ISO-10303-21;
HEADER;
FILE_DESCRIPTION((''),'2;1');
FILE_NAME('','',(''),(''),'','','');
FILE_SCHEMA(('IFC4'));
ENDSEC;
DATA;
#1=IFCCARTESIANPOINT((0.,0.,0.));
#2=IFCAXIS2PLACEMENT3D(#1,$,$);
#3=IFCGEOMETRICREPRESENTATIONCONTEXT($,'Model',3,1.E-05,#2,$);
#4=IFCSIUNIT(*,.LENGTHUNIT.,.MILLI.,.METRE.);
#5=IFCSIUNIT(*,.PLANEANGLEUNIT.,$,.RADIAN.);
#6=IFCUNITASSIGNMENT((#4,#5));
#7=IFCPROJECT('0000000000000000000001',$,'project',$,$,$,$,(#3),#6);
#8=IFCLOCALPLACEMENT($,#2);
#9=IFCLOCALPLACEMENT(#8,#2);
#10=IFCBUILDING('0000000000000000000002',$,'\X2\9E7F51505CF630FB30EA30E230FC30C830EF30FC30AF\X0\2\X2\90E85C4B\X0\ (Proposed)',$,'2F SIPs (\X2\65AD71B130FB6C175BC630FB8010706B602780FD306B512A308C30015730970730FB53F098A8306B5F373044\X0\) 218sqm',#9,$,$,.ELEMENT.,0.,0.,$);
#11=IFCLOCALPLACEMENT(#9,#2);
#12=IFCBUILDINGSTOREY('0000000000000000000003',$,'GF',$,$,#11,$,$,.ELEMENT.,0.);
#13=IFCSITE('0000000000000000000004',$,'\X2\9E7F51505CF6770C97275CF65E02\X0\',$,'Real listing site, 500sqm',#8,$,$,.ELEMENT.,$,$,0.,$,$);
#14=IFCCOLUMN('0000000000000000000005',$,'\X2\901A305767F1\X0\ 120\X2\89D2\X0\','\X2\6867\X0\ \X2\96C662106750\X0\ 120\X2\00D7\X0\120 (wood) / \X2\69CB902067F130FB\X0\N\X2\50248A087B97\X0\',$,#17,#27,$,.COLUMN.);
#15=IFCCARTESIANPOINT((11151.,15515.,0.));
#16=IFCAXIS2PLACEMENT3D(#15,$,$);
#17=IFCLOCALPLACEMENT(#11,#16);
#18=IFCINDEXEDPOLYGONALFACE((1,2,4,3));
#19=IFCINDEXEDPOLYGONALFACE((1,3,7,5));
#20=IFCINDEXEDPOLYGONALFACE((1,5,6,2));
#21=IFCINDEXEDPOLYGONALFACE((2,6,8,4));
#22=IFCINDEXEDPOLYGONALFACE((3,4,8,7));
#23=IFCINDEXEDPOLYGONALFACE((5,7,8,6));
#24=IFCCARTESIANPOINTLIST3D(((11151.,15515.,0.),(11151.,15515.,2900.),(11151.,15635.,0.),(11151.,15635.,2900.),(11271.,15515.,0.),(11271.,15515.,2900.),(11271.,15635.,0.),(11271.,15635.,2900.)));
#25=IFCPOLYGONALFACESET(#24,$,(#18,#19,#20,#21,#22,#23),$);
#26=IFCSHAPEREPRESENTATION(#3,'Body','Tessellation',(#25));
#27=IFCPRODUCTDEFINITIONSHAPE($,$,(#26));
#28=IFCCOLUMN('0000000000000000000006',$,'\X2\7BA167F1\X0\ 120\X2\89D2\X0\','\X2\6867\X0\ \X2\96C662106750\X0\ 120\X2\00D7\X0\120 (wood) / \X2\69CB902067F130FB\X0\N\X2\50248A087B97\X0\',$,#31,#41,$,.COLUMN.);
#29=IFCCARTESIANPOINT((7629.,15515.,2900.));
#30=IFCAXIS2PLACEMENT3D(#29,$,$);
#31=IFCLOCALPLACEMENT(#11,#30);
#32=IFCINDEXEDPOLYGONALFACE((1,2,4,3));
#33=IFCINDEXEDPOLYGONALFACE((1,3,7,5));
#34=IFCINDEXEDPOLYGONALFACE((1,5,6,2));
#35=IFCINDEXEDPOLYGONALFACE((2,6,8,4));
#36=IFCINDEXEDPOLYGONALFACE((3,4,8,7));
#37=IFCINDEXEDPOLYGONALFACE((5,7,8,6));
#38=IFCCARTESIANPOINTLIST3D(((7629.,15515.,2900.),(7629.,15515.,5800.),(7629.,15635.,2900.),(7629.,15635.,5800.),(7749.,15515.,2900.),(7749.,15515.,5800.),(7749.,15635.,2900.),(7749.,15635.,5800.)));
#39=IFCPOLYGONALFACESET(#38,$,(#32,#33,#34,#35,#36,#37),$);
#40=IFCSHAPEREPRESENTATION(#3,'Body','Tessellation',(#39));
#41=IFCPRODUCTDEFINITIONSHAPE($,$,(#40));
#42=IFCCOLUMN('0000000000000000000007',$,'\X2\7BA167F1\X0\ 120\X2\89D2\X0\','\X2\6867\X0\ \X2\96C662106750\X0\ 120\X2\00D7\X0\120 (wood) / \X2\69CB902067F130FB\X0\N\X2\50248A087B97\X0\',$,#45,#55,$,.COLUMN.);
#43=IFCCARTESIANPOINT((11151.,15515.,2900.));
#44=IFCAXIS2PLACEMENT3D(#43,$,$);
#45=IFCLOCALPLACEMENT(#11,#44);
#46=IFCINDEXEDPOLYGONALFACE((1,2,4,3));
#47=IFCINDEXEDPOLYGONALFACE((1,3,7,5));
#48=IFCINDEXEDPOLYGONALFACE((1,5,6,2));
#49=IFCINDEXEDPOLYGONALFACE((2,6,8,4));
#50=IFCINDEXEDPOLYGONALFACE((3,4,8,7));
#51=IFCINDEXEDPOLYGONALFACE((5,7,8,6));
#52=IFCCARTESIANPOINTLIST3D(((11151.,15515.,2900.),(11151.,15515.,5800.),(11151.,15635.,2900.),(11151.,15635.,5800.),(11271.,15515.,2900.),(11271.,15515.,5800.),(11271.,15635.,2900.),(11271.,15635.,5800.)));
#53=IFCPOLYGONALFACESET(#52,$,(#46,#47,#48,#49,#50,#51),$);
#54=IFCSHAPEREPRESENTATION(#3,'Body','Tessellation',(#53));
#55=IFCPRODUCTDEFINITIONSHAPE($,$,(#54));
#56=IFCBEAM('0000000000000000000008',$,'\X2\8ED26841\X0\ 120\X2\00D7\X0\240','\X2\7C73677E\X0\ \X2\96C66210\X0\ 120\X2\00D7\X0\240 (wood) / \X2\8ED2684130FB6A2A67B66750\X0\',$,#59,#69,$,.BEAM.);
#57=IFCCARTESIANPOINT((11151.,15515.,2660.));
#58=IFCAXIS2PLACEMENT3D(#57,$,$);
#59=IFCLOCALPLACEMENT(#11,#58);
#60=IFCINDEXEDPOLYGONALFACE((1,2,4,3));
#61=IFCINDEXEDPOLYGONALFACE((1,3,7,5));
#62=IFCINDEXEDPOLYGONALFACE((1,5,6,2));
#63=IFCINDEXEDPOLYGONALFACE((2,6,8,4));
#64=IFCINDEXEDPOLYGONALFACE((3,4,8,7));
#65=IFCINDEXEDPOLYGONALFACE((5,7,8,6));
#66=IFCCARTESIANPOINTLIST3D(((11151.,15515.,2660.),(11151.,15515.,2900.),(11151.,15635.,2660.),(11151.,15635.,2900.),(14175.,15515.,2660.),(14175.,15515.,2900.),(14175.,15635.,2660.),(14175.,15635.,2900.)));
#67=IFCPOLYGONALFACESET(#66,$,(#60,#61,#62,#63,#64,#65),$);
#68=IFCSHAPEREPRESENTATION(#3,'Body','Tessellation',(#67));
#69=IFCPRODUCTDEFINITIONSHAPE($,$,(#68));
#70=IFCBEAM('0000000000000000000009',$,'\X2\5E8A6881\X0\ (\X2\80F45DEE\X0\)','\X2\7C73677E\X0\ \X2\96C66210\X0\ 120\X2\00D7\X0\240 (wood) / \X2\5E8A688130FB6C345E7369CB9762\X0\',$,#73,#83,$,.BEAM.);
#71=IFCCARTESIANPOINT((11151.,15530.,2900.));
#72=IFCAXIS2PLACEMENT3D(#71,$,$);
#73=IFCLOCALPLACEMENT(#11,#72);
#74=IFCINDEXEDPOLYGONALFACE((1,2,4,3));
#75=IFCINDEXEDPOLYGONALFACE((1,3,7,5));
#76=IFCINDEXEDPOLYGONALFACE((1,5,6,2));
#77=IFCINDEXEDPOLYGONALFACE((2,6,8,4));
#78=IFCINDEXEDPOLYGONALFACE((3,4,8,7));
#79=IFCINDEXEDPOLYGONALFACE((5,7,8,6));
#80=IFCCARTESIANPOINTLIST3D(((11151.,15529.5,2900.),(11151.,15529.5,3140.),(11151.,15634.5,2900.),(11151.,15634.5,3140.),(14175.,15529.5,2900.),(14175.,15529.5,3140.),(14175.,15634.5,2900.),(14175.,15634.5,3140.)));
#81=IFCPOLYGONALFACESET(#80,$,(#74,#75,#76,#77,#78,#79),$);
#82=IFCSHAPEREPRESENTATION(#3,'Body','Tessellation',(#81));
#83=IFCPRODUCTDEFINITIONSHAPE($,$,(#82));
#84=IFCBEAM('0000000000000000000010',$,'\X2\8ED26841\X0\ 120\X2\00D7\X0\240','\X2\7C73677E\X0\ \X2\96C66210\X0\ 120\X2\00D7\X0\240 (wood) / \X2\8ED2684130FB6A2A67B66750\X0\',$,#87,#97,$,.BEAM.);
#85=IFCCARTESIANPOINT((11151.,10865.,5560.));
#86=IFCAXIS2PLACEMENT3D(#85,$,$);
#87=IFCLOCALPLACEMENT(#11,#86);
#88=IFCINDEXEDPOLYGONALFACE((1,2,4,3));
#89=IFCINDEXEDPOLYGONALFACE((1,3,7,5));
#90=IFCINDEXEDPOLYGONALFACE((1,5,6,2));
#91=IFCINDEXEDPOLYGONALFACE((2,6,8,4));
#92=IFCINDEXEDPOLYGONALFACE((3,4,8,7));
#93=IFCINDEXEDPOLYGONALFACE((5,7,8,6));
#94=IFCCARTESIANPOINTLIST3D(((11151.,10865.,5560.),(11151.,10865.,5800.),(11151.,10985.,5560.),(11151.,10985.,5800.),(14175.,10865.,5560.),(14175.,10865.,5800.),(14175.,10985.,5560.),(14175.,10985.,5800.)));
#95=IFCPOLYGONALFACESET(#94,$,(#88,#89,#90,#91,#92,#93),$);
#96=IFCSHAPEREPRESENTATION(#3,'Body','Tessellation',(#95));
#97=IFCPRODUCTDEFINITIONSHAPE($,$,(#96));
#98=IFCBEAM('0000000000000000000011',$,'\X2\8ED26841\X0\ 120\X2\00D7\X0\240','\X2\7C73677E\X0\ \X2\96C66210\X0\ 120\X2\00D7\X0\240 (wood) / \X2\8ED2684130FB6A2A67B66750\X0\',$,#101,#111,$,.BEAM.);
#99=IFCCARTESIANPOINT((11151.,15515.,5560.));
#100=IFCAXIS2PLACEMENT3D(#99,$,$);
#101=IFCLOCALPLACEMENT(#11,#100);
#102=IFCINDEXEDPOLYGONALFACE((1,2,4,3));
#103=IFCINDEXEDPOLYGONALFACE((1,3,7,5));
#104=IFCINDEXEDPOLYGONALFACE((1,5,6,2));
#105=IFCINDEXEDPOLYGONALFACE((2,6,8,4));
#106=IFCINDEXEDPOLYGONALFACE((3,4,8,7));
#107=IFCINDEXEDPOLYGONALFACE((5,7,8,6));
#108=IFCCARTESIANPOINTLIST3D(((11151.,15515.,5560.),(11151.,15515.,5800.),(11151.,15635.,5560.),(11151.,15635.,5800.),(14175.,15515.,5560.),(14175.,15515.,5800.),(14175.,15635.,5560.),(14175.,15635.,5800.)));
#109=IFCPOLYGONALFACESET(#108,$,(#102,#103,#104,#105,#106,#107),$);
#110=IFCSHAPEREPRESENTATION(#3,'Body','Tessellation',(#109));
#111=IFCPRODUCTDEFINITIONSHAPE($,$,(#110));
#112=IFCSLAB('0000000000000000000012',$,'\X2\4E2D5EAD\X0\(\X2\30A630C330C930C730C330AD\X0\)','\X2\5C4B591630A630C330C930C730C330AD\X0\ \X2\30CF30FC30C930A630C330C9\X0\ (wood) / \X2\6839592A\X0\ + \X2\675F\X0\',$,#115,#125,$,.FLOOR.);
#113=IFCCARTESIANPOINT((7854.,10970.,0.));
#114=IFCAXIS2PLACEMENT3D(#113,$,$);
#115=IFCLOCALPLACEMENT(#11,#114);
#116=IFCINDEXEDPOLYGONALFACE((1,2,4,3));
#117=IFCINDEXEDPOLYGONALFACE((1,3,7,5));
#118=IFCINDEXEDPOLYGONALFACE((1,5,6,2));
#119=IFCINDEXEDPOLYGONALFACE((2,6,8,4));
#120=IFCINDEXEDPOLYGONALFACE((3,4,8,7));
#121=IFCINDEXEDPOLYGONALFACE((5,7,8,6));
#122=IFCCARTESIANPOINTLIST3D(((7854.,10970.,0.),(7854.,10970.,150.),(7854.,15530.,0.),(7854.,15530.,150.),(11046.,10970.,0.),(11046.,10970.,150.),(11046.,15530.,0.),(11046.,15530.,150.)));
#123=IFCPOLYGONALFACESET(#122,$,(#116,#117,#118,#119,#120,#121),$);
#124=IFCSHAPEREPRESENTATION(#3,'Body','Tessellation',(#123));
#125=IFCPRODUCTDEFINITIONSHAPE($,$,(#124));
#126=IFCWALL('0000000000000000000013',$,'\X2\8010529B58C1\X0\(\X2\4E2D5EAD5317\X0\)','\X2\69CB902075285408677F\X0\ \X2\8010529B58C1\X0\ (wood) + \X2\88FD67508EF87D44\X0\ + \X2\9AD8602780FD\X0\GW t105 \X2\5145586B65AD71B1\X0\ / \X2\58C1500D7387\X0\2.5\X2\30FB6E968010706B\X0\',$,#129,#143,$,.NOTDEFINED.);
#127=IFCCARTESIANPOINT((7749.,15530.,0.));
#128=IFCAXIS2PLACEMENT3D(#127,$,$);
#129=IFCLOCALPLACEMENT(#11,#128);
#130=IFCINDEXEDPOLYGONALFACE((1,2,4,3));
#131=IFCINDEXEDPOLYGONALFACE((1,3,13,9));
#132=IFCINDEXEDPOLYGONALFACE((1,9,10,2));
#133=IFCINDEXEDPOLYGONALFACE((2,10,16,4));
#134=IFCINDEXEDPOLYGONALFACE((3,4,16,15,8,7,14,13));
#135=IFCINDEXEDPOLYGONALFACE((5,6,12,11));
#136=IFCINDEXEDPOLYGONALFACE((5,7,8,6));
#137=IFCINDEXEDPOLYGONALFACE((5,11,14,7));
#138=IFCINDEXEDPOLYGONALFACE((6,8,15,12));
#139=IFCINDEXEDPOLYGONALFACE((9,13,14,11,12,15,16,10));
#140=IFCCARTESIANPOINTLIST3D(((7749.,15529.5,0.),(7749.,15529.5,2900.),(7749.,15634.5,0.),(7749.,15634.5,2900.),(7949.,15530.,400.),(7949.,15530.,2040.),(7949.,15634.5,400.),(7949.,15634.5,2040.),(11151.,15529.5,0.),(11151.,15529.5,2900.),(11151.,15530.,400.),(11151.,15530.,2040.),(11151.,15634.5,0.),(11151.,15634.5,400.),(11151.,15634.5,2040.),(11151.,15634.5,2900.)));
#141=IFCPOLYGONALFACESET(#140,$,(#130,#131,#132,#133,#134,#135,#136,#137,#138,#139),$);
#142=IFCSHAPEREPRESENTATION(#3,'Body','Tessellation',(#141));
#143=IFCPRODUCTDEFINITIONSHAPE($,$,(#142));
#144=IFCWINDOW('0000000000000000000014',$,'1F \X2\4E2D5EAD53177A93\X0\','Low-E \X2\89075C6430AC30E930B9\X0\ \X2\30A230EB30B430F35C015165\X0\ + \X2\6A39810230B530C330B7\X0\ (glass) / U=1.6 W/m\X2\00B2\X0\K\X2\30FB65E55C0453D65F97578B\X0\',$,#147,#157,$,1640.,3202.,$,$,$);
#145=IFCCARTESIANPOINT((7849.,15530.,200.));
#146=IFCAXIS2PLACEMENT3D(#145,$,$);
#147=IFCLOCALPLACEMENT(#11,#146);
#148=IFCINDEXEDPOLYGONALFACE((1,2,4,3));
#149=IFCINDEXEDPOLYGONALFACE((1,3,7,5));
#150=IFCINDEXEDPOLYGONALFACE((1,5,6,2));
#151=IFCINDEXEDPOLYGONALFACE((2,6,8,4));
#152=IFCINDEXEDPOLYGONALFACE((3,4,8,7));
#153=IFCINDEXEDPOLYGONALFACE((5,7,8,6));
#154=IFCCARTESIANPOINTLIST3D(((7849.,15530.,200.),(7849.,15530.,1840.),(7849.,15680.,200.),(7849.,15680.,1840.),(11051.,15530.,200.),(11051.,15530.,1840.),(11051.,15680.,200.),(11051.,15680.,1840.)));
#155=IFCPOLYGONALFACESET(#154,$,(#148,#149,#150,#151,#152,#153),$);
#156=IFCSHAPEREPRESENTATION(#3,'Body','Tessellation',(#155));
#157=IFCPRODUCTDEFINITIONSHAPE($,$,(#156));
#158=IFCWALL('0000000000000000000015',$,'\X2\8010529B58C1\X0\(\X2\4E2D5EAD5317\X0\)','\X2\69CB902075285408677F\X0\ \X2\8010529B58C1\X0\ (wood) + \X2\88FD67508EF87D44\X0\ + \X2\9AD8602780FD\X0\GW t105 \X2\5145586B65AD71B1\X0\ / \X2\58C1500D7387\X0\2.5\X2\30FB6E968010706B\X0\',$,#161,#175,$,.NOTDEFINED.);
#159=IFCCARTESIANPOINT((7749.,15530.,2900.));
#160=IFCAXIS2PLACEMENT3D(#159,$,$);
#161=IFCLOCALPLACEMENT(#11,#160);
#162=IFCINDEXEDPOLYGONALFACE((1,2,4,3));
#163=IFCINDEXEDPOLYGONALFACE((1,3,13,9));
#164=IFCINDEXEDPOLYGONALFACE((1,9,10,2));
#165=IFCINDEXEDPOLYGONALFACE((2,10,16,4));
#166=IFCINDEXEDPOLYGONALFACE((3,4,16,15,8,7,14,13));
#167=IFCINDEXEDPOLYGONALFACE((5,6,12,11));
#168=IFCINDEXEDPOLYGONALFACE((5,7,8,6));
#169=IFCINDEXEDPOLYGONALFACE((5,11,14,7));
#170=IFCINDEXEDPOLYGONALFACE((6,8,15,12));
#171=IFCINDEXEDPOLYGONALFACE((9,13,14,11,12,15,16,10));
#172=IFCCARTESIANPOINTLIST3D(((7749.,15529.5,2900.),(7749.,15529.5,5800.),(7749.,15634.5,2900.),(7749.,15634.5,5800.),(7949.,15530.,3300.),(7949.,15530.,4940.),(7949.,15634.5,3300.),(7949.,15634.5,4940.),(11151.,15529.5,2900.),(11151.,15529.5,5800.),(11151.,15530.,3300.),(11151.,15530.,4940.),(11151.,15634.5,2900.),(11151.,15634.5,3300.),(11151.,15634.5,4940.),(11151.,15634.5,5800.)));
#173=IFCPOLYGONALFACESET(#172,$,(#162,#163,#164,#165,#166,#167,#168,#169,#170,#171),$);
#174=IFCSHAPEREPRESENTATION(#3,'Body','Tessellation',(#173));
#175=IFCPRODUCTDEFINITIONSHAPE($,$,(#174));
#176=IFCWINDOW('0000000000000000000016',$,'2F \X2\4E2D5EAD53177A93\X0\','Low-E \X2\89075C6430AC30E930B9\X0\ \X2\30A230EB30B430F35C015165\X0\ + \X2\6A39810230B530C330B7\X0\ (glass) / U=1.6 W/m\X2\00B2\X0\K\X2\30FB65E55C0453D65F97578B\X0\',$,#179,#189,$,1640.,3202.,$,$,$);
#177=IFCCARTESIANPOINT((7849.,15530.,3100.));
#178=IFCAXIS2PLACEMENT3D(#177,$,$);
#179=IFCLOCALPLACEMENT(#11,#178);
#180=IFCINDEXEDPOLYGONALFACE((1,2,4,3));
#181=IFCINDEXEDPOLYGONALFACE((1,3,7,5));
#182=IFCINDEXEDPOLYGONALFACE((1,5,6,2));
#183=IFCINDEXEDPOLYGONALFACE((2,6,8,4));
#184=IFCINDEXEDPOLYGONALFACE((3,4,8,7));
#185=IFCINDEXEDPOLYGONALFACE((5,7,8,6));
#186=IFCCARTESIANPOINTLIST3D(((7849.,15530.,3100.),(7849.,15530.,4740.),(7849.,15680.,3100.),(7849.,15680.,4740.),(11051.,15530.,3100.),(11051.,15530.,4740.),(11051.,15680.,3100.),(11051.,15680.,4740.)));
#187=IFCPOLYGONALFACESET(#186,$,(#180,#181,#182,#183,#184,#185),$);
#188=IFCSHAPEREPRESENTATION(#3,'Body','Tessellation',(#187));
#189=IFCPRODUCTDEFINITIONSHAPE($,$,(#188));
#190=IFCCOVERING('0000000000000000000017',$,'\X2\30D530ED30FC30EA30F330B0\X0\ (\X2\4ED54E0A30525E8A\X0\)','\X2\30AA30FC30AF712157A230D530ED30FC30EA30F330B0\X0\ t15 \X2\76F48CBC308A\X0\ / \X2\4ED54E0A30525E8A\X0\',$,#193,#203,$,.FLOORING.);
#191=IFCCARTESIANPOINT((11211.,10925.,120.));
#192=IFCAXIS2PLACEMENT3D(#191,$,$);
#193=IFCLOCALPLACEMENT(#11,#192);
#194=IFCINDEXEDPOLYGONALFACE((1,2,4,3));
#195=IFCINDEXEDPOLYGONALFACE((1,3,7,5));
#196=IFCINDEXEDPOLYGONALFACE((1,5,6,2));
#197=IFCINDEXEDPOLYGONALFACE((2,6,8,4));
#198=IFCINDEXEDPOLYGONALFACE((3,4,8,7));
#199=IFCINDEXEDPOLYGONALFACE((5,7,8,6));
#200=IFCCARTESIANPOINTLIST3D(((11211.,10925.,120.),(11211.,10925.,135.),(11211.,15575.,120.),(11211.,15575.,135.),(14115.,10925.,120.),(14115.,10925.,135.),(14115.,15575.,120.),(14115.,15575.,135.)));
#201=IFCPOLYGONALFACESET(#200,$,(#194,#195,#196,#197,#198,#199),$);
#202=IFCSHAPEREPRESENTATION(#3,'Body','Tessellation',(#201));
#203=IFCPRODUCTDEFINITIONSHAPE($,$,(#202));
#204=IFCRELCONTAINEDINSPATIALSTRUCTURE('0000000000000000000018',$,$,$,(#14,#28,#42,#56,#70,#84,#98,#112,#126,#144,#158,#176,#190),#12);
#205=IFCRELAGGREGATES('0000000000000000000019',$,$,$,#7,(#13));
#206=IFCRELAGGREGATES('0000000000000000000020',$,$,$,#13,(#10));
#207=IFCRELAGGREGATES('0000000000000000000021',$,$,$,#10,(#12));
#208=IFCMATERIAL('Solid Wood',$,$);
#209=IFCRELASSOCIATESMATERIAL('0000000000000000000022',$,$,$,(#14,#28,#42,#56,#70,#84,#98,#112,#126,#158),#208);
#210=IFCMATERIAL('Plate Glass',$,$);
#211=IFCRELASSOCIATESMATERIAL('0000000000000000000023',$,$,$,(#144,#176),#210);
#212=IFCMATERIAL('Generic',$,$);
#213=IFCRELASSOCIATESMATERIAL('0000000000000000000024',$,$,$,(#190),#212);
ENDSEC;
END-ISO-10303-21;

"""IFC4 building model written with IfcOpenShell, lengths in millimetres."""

from ifc_helpers import new_model, si_unit, frame, frame_2d, origin, place, context, project, spatial, rectangle, extrude, material, element, fill, save


model = new_model("IFC4")

# Units and contexts
model_context = context("Model", 3, precision=1e-05, world=origin())
ifc_project = project(units=[si_unit("LENGTHUNIT", "METRE", prefix="MILLI"), si_unit("PLANEANGLEUNIT", "RADIAN")], contexts=[model_context])

# Site, building, storey
site_placement = place(None, origin())
site = spatial("IfcSite", under=ifc_project, at=site_placement, Name="鹿児島県霧島市", ObjectType="Real listing site, 500sqm", CompositionType="ELEMENT", RefElevation=0.0)
building_placement = place(site_placement, origin())
building = spatial("IfcBuilding", under=site, at=building_placement, Name="鹿児島・リモートワーク2部屋 (Proposed)", ObjectType="2F SIPs (断熱・気密・耐火性能に優れ、地震・台風に強い) 218sqm", CompositionType="ELEMENT", ElevationOfRefHeight=0.0, ElevationOfTerrain=0.0)
storey_placement = place(building_placement, origin())
storey = spatial("IfcBuildingStorey", under=building, at=storey_placement, Name="GF", CompositionType="ELEMENT", Elevation=0.0)

# Columns
ifc_material_1 = material(Name="Solid Wood")
column_1_placement = place(storey_placement, frame((11151.0, 15515.0, 0.0)))
element("IfcColumn", 1, at=column_1_placement, inside=storey, material=ifc_material_1, Name="通し柱 120角", Description="桧 集成材 120×120 (wood) / 構造柱・N値計算", PredefinedType="COLUMN", context=model_context, shape_type="SweptSolid", body=[
    extrude(rectangle(XDim=120.0, YDim=120.0, at=frame_2d((60.0, 60.0))), frame((11151.0, 15515.0, 0.0)), (0.0, 0.0, 1.0), 2900.0),
])
column_2_placement = place(storey_placement, frame((7629.0, 15515.0, 2900.0)))
element("IfcColumn", 2, at=column_2_placement, inside=storey, material=ifc_material_1, Name="管柱 120角", Description="桧 集成材 120×120 (wood) / 構造柱・N値計算", PredefinedType="COLUMN", context=model_context, shape_type="SweptSolid", body=[
    extrude(rectangle(XDim=120.0, YDim=120.0, at=frame_2d((60.0, 60.0))), frame((7629.0, 15515.0, 2900.0)), (0.0, 0.0, 1.0), 2900.0),
])
column_3_placement = place(storey_placement, frame((11151.0, 15515.0, 2900.0)))
element("IfcColumn", 3, at=column_3_placement, inside=storey, material=ifc_material_1, Name="管柱 120角", Description="桧 集成材 120×120 (wood) / 構造柱・N値計算", PredefinedType="COLUMN", context=model_context, shape_type="SweptSolid", body=[
    extrude(rectangle(XDim=120.0, YDim=120.0, at=frame_2d((60.0, 60.0))), frame((11151.0, 15515.0, 2900.0)), (0.0, 0.0, 1.0), 2900.0),
])

# Beams
beam_1_placement = place(storey_placement, frame((11151.0, 15515.0, 2660.0)))
element("IfcBeam", 4, at=beam_1_placement, inside=storey, material=ifc_material_1, Name="軒桁 120×240", Description="米松 集成 120×240 (wood) / 軒桁・横架材", PredefinedType="BEAM", context=model_context, shape_type="SweptSolid", body=[
    extrude(rectangle(XDim=3024.0, YDim=120.0, at=frame_2d((1512.0, 60.0))), frame((11151.0, 15515.0, 2660.0)), (0.0, 0.0, 1.0), 240.0),
])
beam_2_placement = place(storey_placement, frame((11151.0, 15530.0, 2900.0)))
element("IfcBeam", 5, at=beam_2_placement, inside=storey, material=ifc_material_1, Name="床梁 (胴差)", Description="米松 集成 120×240 (wood) / 床梁・水平構面", PredefinedType="BEAM", context=model_context, shape_type="SweptSolid", body=[
    extrude(rectangle(XDim=3024.0, YDim=105.0, at=frame_2d((1512.0, 52.0))), frame((11151.0, 15530.0, 2900.0)), (0.0, 0.0, 1.0), 240.0),
])
beam_3_placement = place(storey_placement, frame((11151.0, 10865.0, 5560.0)))
element("IfcBeam", 6, at=beam_3_placement, inside=storey, material=ifc_material_1, Name="軒桁 120×240", Description="米松 集成 120×240 (wood) / 軒桁・横架材", PredefinedType="BEAM", context=model_context, shape_type="SweptSolid", body=[
    extrude(rectangle(XDim=3024.0, YDim=120.0, at=frame_2d((1512.0, 60.0))), frame((11151.0, 10865.0, 5560.0)), (0.0, 0.0, 1.0), 240.0),
])
beam_4_placement = place(storey_placement, frame((11151.0, 15515.0, 5560.0)))
element("IfcBeam", 7, at=beam_4_placement, inside=storey, material=ifc_material_1, Name="軒桁 120×240", Description="米松 集成 120×240 (wood) / 軒桁・横架材", PredefinedType="BEAM", context=model_context, shape_type="SweptSolid", body=[
    extrude(rectangle(XDim=3024.0, YDim=120.0, at=frame_2d((1512.0, 60.0))), frame((11151.0, 15515.0, 5560.0)), (0.0, 0.0, 1.0), 240.0),
])

# Slab
slab_placement = place(storey_placement, frame((7854.0, 10970.0, 0.0)))
element("IfcSlab", 8, at=slab_placement, inside=storey, material=ifc_material_1, Name="中庭(ウッドデッキ)", Description="屋外ウッドデッキ ハードウッド (wood) / 根太 + 束", PredefinedType="FLOOR", context=model_context, shape_type="SweptSolid", body=[
    extrude(rectangle(XDim=3192.0, YDim=4560.0, at=frame_2d((1596.0, 2280.0))), frame((7854.0, 10970.0, 0.0)), (0.0, 0.0, 1.0), 150.0),
])

# Wall, opening, window
wall_1_placement = place(storey_placement, frame((7749.0, 15530.0, 0.0)))
wall_1 = element("IfcWall", 9, at=wall_1_placement, inside=storey, material=ifc_material_1, Name="耐力壁(中庭北)", Description="構造用合板 耐力壁 (wood) + 製材軸組 + 高性能GW t105 充填断熱 / 壁倍率2.5・準耐火", PredefinedType="NOTDEFINED", context=model_context, shape_type="SweptSolid", body=[
    extrude(rectangle(XDim=3402.0, YDim=105.0, at=frame_2d((1701.0, 52.0))), frame((7749.0, 15530.0, 0.0)), (0.0, 0.0, 1.0), 2900.0),
])
opening_1_placement = place(storey_placement, frame((7849.0, 15530.0, 200.0)))
opening_1 = element("IfcOpeningElement", 10, at=opening_1_placement, cuts=wall_1, PredefinedType="NOTDEFINED", context=model_context, shape_type="SweptSolid", body=[
    extrude(rectangle(XDim=3202.0, YDim=150.0, at=frame_2d((1601.0, 75.0))), frame((7849.0, 15530.0, 200.0)), (0.0, 0.0, 1.0), 1640.0),
])
ifc_material_2 = material(Name="Plate Glass")
window_1_placement = place(storey_placement, frame((7849.0, 15530.0, 200.0)))
window_1 = element("IfcWindow", 11, at=window_1_placement, inside=storey, material=ifc_material_2, Name="1F 中庭北窓", Description="Low-E 複層ガラス アルゴン封入 + 樹脂サッシ (glass) / U=1.6 W/m²K・日射取得型", OverallHeight=1640.0, OverallWidth=3202.0, context=model_context, shape_type="SweptSolid", body=[
    extrude(rectangle(XDim=3202.0, YDim=150.0, at=frame_2d((1601.0, 75.0))), frame((7849.0, 15530.0, 200.0)), (0.0, 0.0, 1.0), 1640.0),
])
fill(opening_1, window_1)

# Wall, opening, window
wall_2_placement = place(storey_placement, frame((7749.0, 15530.0, 2900.0)))
wall_2 = element("IfcWall", 12, at=wall_2_placement, inside=storey, material=ifc_material_1, Name="耐力壁(中庭北)", Description="構造用合板 耐力壁 (wood) + 製材軸組 + 高性能GW t105 充填断熱 / 壁倍率2.5・準耐火", PredefinedType="NOTDEFINED", context=model_context, shape_type="SweptSolid", body=[
    extrude(rectangle(XDim=3402.0, YDim=105.0, at=frame_2d((1701.0, 52.0))), frame((7749.0, 15530.0, 2900.0)), (0.0, 0.0, 1.0), 2900.0),
])
opening_2_placement = place(storey_placement, frame((7849.0, 15530.0, 3100.0)))
opening_2 = element("IfcOpeningElement", 13, at=opening_2_placement, cuts=wall_2, PredefinedType="NOTDEFINED", context=model_context, shape_type="SweptSolid", body=[
    extrude(rectangle(XDim=3202.0, YDim=150.0, at=frame_2d((1601.0, 75.0))), frame((7849.0, 15530.0, 3100.0)), (0.0, 0.0, 1.0), 1640.0),
])
window_2_placement = place(storey_placement, frame((7849.0, 15530.0, 3100.0)))
window_2 = element("IfcWindow", 14, at=window_2_placement, inside=storey, material=ifc_material_2, Name="2F 中庭北窓", Description="Low-E 複層ガラス アルゴン封入 + 樹脂サッシ (glass) / U=1.6 W/m²K・日射取得型", OverallHeight=1640.0, OverallWidth=3202.0, context=model_context, shape_type="SweptSolid", body=[
    extrude(rectangle(XDim=3202.0, YDim=150.0, at=frame_2d((1601.0, 75.0))), frame((7849.0, 15530.0, 3100.0)), (0.0, 0.0, 1.0), 1640.0),
])
fill(opening_2, window_2)

# Covering
ifc_material_3 = material(Name="Generic")
covering_1_placement = place(storey_placement, frame((11211.0, 10925.0, 120.0)))
element("IfcCovering", 15, at=covering_1_placement, inside=storey, material=ifc_material_3, Name="フローリング (仕上げ床)", Description="オーク無垢フローリング t15 直貼り / 仕上げ床", PredefinedType="FLOORING", context=model_context, shape_type="SweptSolid", body=[
    extrude(rectangle(XDim=2904.0, YDim=4650.0, at=frame_2d((1452.0, 2325.0))), frame((11211.0, 10925.0, 120.0)), (0.0, 0.0, 1.0), 15.0),
])

save(model, "model.ifc")
